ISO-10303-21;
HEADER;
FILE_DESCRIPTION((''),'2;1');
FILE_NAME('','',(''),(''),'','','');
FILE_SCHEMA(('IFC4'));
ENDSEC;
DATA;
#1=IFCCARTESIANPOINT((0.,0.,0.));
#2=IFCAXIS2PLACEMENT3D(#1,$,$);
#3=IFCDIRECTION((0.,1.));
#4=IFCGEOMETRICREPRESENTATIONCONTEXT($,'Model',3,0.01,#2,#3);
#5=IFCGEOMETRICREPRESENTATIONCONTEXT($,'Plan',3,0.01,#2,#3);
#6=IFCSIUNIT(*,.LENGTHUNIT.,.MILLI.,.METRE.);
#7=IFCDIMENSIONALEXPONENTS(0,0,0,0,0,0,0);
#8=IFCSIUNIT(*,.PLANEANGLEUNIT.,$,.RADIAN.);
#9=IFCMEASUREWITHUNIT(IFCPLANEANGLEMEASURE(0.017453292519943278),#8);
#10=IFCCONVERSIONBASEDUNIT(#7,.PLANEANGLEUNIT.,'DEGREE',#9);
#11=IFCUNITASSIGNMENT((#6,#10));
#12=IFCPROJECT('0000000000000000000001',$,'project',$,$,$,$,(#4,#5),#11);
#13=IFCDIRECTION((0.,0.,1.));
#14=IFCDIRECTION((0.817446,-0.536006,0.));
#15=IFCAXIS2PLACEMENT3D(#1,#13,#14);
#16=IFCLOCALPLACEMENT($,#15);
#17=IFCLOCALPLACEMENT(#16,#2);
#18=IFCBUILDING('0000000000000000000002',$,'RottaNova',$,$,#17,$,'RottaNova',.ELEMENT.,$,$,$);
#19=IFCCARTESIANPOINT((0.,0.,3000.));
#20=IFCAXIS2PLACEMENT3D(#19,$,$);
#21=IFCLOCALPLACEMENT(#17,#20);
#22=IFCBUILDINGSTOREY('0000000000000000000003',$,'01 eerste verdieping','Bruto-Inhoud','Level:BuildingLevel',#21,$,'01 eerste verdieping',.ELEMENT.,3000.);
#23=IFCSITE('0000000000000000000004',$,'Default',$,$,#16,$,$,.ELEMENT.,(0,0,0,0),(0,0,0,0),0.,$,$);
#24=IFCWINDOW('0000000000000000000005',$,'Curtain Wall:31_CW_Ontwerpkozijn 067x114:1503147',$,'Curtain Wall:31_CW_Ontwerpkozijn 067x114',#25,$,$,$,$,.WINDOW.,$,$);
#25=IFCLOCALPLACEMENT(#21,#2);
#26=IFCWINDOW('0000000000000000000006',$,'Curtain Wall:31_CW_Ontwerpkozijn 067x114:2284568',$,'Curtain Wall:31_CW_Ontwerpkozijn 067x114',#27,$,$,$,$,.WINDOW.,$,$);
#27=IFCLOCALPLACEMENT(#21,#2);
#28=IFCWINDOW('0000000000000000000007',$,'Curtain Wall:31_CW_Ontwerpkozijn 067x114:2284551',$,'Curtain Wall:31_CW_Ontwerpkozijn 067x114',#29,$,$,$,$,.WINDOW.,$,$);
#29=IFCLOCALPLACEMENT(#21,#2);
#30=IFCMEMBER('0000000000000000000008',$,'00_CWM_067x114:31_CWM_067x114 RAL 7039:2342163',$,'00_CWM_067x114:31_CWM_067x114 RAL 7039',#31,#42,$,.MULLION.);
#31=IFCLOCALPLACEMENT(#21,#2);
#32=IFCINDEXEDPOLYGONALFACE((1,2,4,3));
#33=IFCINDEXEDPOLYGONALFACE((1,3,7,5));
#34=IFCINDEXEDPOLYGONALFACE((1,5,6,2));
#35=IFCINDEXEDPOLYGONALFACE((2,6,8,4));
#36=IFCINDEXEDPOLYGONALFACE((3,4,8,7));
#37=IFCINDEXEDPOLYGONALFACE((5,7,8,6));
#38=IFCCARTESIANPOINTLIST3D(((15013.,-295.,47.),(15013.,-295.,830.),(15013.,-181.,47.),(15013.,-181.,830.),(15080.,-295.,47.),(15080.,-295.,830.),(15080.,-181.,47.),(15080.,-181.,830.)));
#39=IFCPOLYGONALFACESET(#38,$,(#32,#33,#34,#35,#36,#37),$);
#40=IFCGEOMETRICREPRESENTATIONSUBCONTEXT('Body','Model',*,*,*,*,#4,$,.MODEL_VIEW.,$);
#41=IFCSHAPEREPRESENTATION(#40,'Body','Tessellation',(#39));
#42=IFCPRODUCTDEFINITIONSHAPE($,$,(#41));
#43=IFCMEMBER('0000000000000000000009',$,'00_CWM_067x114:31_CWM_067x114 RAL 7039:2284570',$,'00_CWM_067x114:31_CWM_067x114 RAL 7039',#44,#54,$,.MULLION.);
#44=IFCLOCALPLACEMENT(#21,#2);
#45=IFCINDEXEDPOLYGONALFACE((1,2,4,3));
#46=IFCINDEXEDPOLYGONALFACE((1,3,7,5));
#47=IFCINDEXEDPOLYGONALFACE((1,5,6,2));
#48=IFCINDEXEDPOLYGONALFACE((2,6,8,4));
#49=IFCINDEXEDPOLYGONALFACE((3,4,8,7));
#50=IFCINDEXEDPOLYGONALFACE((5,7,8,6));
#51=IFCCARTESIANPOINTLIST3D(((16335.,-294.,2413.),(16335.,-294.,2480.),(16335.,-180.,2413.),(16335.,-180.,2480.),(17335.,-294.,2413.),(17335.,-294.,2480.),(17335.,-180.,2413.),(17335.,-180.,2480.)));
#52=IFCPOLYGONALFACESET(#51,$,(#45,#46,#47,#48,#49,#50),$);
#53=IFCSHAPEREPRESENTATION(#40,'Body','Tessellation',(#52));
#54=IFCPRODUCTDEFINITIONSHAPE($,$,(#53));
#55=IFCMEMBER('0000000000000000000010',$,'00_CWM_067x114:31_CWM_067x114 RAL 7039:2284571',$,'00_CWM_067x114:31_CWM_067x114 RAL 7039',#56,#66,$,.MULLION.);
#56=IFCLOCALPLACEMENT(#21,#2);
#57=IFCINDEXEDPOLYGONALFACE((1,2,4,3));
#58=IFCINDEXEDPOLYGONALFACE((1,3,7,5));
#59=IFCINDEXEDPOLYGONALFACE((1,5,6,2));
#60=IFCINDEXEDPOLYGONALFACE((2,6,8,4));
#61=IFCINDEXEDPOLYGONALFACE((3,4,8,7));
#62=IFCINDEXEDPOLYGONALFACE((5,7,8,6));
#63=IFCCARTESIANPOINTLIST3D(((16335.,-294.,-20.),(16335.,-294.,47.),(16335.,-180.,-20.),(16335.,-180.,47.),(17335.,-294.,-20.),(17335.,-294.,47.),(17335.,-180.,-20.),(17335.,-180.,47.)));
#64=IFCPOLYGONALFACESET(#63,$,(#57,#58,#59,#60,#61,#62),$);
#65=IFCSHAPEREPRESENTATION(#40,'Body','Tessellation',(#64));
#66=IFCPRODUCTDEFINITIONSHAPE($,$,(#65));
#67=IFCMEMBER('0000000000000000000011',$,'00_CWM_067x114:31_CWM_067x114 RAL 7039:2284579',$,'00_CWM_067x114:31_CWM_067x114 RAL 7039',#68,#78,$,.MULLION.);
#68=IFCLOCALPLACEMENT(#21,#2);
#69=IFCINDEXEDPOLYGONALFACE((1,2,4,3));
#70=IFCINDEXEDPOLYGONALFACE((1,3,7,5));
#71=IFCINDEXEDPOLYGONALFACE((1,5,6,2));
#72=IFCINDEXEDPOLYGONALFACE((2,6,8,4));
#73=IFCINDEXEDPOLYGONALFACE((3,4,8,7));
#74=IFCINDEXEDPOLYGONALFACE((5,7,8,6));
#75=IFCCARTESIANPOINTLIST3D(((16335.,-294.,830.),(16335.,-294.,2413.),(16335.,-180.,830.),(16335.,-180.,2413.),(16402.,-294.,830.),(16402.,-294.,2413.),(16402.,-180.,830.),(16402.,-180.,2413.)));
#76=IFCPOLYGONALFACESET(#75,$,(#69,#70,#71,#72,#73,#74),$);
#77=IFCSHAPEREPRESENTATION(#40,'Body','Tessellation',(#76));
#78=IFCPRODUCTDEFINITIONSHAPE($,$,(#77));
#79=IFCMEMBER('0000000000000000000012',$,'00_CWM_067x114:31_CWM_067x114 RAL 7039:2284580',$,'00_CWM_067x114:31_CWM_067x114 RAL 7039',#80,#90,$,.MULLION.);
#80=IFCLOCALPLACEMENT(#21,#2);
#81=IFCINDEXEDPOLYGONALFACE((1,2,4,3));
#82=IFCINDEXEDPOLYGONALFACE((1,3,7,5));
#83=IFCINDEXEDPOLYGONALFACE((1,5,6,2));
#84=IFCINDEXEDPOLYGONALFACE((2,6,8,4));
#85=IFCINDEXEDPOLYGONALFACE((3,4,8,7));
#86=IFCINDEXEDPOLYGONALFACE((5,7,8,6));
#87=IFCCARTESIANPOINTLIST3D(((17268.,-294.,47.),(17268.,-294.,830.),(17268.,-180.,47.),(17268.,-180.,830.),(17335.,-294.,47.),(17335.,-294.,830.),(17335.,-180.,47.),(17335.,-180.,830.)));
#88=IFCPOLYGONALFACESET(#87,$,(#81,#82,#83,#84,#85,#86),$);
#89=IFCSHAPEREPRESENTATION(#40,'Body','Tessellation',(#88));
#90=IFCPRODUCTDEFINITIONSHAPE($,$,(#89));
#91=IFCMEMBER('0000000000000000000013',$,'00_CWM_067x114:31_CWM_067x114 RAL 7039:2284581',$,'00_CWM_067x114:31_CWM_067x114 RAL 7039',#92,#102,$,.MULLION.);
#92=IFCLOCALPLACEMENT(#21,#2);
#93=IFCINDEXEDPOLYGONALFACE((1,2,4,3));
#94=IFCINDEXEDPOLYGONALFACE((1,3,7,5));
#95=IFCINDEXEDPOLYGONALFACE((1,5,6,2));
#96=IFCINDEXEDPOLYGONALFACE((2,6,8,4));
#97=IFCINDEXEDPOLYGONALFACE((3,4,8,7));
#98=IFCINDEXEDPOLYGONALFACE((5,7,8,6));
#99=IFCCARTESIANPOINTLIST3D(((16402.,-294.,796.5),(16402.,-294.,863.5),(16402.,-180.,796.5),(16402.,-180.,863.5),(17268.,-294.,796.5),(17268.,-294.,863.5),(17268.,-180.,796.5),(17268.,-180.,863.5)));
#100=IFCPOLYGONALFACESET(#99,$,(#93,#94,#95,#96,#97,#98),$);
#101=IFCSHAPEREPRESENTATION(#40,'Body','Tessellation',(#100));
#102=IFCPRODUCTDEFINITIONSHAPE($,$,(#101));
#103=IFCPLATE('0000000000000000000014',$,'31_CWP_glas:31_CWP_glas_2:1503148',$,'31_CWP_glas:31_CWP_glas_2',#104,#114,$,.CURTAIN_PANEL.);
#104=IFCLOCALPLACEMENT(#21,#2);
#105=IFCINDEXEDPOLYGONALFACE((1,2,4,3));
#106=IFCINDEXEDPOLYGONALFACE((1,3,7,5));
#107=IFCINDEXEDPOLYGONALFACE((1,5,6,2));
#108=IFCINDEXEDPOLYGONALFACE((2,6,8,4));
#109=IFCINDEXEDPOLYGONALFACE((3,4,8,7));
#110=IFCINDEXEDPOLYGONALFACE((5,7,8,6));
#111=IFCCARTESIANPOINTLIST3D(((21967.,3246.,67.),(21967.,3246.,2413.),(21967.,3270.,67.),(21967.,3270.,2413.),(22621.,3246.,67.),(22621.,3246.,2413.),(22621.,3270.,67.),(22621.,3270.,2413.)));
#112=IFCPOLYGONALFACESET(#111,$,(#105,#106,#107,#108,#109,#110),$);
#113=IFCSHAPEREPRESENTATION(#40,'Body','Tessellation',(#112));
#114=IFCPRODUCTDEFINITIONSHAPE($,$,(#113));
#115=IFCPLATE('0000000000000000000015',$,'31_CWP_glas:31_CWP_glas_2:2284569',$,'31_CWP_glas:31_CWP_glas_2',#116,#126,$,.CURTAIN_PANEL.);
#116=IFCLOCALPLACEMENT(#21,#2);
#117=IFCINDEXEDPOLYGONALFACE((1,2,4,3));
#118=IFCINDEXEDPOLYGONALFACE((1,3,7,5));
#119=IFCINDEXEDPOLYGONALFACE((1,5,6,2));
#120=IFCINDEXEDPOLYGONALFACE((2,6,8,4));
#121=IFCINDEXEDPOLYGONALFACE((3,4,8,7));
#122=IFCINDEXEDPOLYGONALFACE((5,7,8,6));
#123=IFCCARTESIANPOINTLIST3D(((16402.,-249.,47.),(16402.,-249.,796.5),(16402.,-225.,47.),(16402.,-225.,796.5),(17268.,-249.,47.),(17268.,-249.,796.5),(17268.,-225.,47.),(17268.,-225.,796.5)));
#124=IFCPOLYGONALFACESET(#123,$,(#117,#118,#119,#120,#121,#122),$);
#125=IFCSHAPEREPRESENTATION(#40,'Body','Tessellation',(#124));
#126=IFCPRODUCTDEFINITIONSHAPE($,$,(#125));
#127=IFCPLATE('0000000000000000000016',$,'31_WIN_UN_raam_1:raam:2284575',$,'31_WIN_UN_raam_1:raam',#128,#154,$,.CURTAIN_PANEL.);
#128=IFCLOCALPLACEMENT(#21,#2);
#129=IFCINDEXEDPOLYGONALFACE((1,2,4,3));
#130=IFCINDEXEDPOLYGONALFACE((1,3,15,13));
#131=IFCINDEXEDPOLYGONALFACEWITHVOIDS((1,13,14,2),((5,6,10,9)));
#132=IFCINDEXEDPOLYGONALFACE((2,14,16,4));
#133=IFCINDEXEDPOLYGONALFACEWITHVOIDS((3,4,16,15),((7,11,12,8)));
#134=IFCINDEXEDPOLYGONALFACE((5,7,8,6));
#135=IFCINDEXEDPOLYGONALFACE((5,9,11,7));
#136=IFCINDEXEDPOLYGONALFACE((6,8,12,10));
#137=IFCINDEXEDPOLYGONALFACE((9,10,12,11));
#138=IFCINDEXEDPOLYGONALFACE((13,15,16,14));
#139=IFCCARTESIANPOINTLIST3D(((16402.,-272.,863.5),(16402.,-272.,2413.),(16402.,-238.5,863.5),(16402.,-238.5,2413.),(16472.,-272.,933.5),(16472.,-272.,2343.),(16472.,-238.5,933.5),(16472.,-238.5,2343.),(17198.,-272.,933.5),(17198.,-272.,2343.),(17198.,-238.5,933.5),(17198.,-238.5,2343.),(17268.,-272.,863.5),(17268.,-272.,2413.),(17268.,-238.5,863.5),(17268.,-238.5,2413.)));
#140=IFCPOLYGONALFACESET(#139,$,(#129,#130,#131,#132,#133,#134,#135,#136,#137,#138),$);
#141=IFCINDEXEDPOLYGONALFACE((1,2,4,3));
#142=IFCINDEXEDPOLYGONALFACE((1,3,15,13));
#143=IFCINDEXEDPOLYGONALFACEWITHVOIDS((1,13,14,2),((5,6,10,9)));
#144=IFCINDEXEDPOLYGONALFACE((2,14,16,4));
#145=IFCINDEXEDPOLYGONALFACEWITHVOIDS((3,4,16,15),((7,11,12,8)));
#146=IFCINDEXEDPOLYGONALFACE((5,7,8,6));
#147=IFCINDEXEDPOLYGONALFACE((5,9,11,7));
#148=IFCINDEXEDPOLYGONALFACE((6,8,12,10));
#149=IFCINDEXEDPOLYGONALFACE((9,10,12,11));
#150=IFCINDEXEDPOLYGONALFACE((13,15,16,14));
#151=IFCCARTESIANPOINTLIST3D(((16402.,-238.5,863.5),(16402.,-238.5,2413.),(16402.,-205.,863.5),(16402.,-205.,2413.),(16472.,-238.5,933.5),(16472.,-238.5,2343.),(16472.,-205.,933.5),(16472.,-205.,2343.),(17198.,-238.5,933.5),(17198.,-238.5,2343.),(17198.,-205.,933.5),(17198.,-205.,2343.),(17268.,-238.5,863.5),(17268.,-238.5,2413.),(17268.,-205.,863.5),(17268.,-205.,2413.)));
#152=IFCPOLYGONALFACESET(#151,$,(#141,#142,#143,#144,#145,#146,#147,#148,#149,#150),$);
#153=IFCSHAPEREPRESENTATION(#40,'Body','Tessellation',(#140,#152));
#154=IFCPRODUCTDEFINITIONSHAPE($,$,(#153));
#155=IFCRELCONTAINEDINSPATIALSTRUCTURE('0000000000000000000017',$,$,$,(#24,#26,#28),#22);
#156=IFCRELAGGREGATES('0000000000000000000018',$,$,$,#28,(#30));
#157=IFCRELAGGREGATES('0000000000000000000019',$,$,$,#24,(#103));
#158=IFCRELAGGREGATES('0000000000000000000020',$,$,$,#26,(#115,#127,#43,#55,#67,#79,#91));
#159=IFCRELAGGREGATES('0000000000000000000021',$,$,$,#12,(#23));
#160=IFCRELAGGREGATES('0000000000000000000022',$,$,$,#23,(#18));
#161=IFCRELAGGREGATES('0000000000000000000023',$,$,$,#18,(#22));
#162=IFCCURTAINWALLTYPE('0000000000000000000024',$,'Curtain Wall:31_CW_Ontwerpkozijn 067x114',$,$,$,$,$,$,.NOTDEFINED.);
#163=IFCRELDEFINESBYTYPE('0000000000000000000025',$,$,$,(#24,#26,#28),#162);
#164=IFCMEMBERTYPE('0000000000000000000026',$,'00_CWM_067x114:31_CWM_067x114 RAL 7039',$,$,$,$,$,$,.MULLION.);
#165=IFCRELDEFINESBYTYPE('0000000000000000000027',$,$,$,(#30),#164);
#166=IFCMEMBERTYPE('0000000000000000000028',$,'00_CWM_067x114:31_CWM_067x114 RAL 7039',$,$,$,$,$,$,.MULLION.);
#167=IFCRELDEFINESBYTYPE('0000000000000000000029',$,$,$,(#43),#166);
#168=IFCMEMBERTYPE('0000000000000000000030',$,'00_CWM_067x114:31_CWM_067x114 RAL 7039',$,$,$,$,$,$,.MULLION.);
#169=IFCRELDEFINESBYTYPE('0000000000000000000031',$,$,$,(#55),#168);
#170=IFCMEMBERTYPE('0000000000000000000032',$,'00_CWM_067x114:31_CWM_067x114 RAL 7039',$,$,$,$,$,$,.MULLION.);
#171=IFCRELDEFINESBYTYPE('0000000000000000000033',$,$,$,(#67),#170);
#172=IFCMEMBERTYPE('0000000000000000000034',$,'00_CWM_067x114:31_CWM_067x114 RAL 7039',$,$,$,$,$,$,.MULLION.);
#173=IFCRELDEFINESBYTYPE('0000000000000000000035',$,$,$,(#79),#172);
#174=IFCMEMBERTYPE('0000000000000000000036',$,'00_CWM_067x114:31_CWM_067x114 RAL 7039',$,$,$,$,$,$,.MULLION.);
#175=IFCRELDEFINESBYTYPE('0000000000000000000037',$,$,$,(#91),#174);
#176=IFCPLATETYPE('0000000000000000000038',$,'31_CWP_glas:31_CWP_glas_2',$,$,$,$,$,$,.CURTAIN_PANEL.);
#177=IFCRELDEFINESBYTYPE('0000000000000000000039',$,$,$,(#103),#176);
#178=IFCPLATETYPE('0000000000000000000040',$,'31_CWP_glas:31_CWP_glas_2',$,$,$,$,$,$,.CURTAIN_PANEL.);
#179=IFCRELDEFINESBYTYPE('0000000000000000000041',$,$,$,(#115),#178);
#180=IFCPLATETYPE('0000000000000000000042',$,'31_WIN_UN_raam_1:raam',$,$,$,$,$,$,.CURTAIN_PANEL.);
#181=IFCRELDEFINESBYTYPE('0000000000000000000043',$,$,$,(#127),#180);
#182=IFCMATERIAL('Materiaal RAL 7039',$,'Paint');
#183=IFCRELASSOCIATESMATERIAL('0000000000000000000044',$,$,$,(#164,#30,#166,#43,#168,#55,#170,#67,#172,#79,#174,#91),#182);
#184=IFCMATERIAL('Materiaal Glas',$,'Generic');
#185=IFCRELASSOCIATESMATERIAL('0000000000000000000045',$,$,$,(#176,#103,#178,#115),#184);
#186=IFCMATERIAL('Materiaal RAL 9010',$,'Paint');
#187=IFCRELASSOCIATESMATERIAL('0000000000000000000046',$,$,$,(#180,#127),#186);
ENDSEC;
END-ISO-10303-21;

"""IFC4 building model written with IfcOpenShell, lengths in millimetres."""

from ifc_helpers import new_model, entity, si_unit, converted_unit, direction, frame, origin, place, context, subcontext, project, spatial, indexed_curve, outline, extrude, source, transform, mapped, material, type_object, type_shapes, element, aggregate, save


model = new_model("IFC4")

# Units and contexts
model_context = context("Model", 3, precision=0.01, world=origin(), true_north=direction((0.0, 1.0)))
plan_context = context("Plan", 3, precision=0.01, world=origin(), true_north=direction((0.0, 1.0)))
body_context = subcontext(model_context, "Body", "Model", "MODEL_VIEW")
ifc_project = project(units=[si_unit("LENGTHUNIT", "METRE", prefix="MILLI"), converted_unit("PLANEANGLEUNIT", "DEGREE", entity("IfcPlaneAngleMeasure", 0.017453292519943278), si_unit("PLANEANGLEUNIT", "RADIAN"), dimensions=[0, 0, 0, 0, 0, 0, 0])], contexts=[model_context, plan_context])

# Site, building, storey
site_placement = place(None, frame((0.0, 0.0, 0.0), z_axis=(0.0, 0.0, 1.0), x_axis=(0.817446, -0.536006, 0.0)))
site = spatial("IfcSite", under=ifc_project, at=site_placement, Name="Default", CompositionType="ELEMENT", RefLatitude=(0, 0, 0, 0), RefLongitude=(0, 0, 0, 0), RefElevation=0.0)
building_placement = place(site_placement, origin())
building = spatial("IfcBuilding", under=site, at=building_placement, Name="RottaNova", LongName="RottaNova", CompositionType="ELEMENT")
storey_placement = place(building_placement, frame((0.0, 0.0, 3000.0)))
storey = spatial("IfcBuildingStorey", under=building, at=storey_placement, Name="01 eerste verdieping", Description="Bruto-Inhoud", ObjectType="Level:BuildingLevel", LongName="01 eerste verdieping", CompositionType="ELEMENT", Elevation=3000.0)

# Window
curtain_wall_type = type_object("IfcCurtainWallType", Name="Curtain Wall:31_CW_Ontwerpkozijn 067x114", PredefinedType="NOTDEFINED")
ifc_material_1 = material(Name="Materiaal RAL 7039", Category="Paint")
window_1_placement = place(storey_placement, frame((0.0, 0.0, -3000.0)))
window_1 = element("IfcWindow", 1, at=window_1_placement, inside=storey, type_object=curtain_wall_type, Name="Curtain Wall:31_CW_Ontwerpkozijn 067x114:1503147", ObjectType="Curtain Wall:31_CW_Ontwerpkozijn 067x114", PredefinedType="WINDOW")

# Window
window_2_placement = place(storey_placement, frame((0.0, 0.0, -3000.0)))
window_2 = element("IfcWindow", 2, at=window_2_placement, inside=storey, type_object=curtain_wall_type, Name="Curtain Wall:31_CW_Ontwerpkozijn 067x114:2284568", ObjectType="Curtain Wall:31_CW_Ontwerpkozijn 067x114", PredefinedType="WINDOW")

# Window, member
window_3_placement = place(storey_placement, frame((0.0, 0.0, -3000.0)))
window_3 = element("IfcWindow", 3, at=window_3_placement, inside=storey, type_object=curtain_wall_type, Name="Curtain Wall:31_CW_Ontwerpkozijn 067x114:2284551", ObjectType="Curtain Wall:31_CW_Ontwerpkozijn 067x114", PredefinedType="WINDOW")
member_type_1 = type_object("IfcMemberType", Name="00_CWM_067x114:31_CWM_067x114 RAL 7039", PredefinedType="MULLION", material=ifc_material_1)
shared_shape_1 = source(origin(), body_context, "Body", "SweptSolid", [
    extrude(outline(indexed_curve([(-33.5, -57.0), (33.5, -57.0), (33.5, 57.0), (-33.5, 57.0), (-33.5, -57.0)], self_intersect=False)), frame((-33.5, -57.0, -783.0), z_axis=(0.0, 0.0, 1.0), x_axis=(-1.0, 0.0, 0.0)), (0.0, 0.0, 1.0), 783.0),
])
type_shapes(member_type_1, [shared_shape_1])
member_1_placement = place(window_3_placement, frame((15080.0, -181.0, 3830.0)))
member_1 = element("IfcMember", 4, at=member_1_placement, type_object=member_type_1, material=ifc_material_1, Name="00_CWM_067x114:31_CWM_067x114 RAL 7039:2342163", ObjectType="00_CWM_067x114:31_CWM_067x114 RAL 7039", PredefinedType="MULLION", context=body_context, shape_type="MappedRepresentation", body=[
    mapped(shared_shape_1, transform((0.0, 0.0, 0.0), scale=1.0)),
])
aggregate(window_3, [member_1])

# Members
member_type_2 = type_object("IfcMemberType", Name="00_CWM_067x114:31_CWM_067x114 RAL 7039", PredefinedType="MULLION", material=ifc_material_1)
shared_shape_2 = source(origin(), body_context, "Body", "SweptSolid", [
    extrude(outline(indexed_curve([(-33.5, -57.0), (33.5, -57.0), (33.5, 57.0), (-33.5, 57.0), (-33.5, -57.0)], self_intersect=False)), frame((-33.5, -57.0, -1000.0), z_axis=(0.0, 0.0, 1.0), x_axis=(-1.0, 0.0, 0.0)), (0.0, 0.0, 1.0), 1000.0),
])
type_shapes(member_type_2, [shared_shape_2])
member_2_placement = place(window_2_placement, frame((16335.0, -180.0, 5480.0), z_axis=(-1.0, 0.0, 0.0), x_axis=(0.0, 0.0, 1.0)))
member_2 = element("IfcMember", 5, at=member_2_placement, type_object=member_type_2, material=ifc_material_1, Name="00_CWM_067x114:31_CWM_067x114 RAL 7039:2284570", ObjectType="00_CWM_067x114:31_CWM_067x114 RAL 7039", PredefinedType="MULLION", context=body_context, shape_type="MappedRepresentation", body=[
    mapped(shared_shape_2, transform((0.0, 0.0, 0.0), scale=1.0)),
])
member_type_3 = type_object("IfcMemberType", Name="00_CWM_067x114:31_CWM_067x114 RAL 7039", PredefinedType="MULLION", material=ifc_material_1)
shared_shape_3 = source(origin(), body_context, "Body", "SweptSolid", [
    extrude(outline(indexed_curve([(-33.5, -57.0), (33.5, -57.0), (33.5, 57.0), (-33.5, 57.0), (-33.5, -57.0)], self_intersect=False)), frame((-33.5, -57.0, -1000.0), z_axis=(0.0, 0.0, 1.0), x_axis=(-1.0, 0.0, 0.0)), (0.0, 0.0, 1.0), 1000.0),
])
type_shapes(member_type_3, [shared_shape_3])
member_3_placement = place(window_2_placement, frame((17335.0, -180.0, 2980.0), z_axis=(1.0, 0.0, 0.0), x_axis=(0.0, 0.0, -1.0)))
member_3 = element("IfcMember", 6, at=member_3_placement, type_object=member_type_3, material=ifc_material_1, Name="00_CWM_067x114:31_CWM_067x114 RAL 7039:2284571", ObjectType="00_CWM_067x114:31_CWM_067x114 RAL 7039", PredefinedType="MULLION", context=body_context, shape_type="MappedRepresentation", body=[
    mapped(shared_shape_3, transform((0.0, 0.0, 0.0), scale=1.0)),
])
member_type_4 = type_object("IfcMemberType", Name="00_CWM_067x114:31_CWM_067x114 RAL 7039", PredefinedType="MULLION", material=ifc_material_1)
shared_shape_4 = source(origin(), body_context, "Body", "SweptSolid", [
    extrude(outline(indexed_curve([(-33.5, -57.0), (33.5, -57.0), (33.5, 57.0), (-33.5, 57.0), (-33.5, -57.0)], self_intersect=False)), frame((-33.5, -57.0, -1583.0), z_axis=(0.0, 0.0, 1.0), x_axis=(-1.0, 0.0, 0.0)), (0.0, 0.0, 1.0), 1583.0),
])
type_shapes(member_type_4, [shared_shape_4])
member_4_placement = place(window_2_placement, frame((16335.0, -180.0, 3830.0), z_axis=(0.0, 0.0, -1.0), x_axis=(-1.0, 0.0, 0.0)))
member_4 = element("IfcMember", 7, at=member_4_placement, type_object=member_type_4, material=ifc_material_1, Name="00_CWM_067x114:31_CWM_067x114 RAL 7039:2284579", ObjectType="00_CWM_067x114:31_CWM_067x114 RAL 7039", PredefinedType="MULLION", context=body_context, shape_type="MappedRepresentation", body=[
    mapped(shared_shape_4, transform((0.0, 0.0, 0.0), scale=1.0)),
])
member_type_5 = type_object("IfcMemberType", Name="00_CWM_067x114:31_CWM_067x114 RAL 7039", PredefinedType="MULLION", material=ifc_material_1)
shared_shape_5 = source(origin(), body_context, "Body", "SweptSolid", [
    extrude(outline(indexed_curve([(-33.5, -57.0), (33.5, -57.0), (33.5, 57.0), (-33.5, 57.0), (-33.5, -57.0)], self_intersect=False)), frame((-33.5, -57.0, -783.0), z_axis=(0.0, 0.0, 1.0), x_axis=(-1.0, 0.0, 0.0)), (0.0, 0.0, 1.0), 783.0),
])
type_shapes(member_type_5, [shared_shape_5])
member_5_placement = place(window_2_placement, frame((17335.0, -180.0, 3830.0)))
member_5 = element("IfcMember", 8, at=member_5_placement, type_object=member_type_5, material=ifc_material_1, Name="00_CWM_067x114:31_CWM_067x114 RAL 7039:2284580", ObjectType="00_CWM_067x114:31_CWM_067x114 RAL 7039", PredefinedType="MULLION", context=body_context, shape_type="MappedRepresentation", body=[
    mapped(shared_shape_5, transform((0.0, 0.0, 0.0), scale=1.0)),
])
member_type_6 = type_object("IfcMemberType", Name="00_CWM_067x114:31_CWM_067x114 RAL 7039", PredefinedType="MULLION", material=ifc_material_1)
shared_shape_6 = source(origin(), body_context, "Body", "SweptSolid", [
    extrude(outline(indexed_curve([(-33.5, -57.0), (33.5, -57.0), (33.5, 57.0), (-33.5, 57.0), (-33.5, -57.0)], self_intersect=False)), frame((0.0, -57.0, -866.0), z_axis=(0.0, 0.0, 1.0), x_axis=(-1.0, 0.0, 0.0)), (0.0, 0.0, 1.0), 866.0),
])
type_shapes(member_type_6, [shared_shape_6])
member_6_placement = place(window_2_placement, frame((16402.0, -180.0, 3830.0), z_axis=(-1.0, 0.0, 0.0), x_axis=(0.0, 0.0, 1.0)))
member_6 = element("IfcMember", 9, at=member_6_placement, type_object=member_type_6, material=ifc_material_1, Name="00_CWM_067x114:31_CWM_067x114 RAL 7039:2284581", ObjectType="00_CWM_067x114:31_CWM_067x114 RAL 7039", PredefinedType="MULLION", context=body_context, shape_type="MappedRepresentation", body=[
    mapped(shared_shape_6, transform((0.0, 0.0, 0.0), scale=1.0)),
])

# Plates
ifc_material_2 = material(Name="Materiaal Glas", Category="Generic")
plate_type_1 = type_object("IfcPlateType", Name="31_CWP_glas:31_CWP_glas_2", PredefinedType="CURTAIN_PANEL", material=ifc_material_2)
shared_shape_7 = source(origin(), body_context, "Body", "SweptSolid", [
    extrude(outline(indexed_curve([(-12.0, -327.0), (12.0, -327.0), (12.0, 327.0), (-12.0, 327.0), (-12.0, -327.0)], self_intersect=False)), frame((0.0, -57.0, 0.0), z_axis=(0.0, 0.0, 1.0), x_axis=(0.0, 1.0, 0.0)), (0.0, 0.0, 1.0), 2346.0),
])
type_shapes(plate_type_1, [shared_shape_7])
plate_1_placement = place(window_1_placement, frame((22294.0, 3315.0, 3067.0)))
plate_1 = element("IfcPlate", 10, at=plate_1_placement, type_object=plate_type_1, material=ifc_material_2, Name="31_CWP_glas:31_CWP_glas_2:1503148", ObjectType="31_CWP_glas:31_CWP_glas_2", PredefinedType="CURTAIN_PANEL", context=body_context, shape_type="MappedRepresentation", body=[
    mapped(shared_shape_7, transform((0.0, 0.0, 0.0), scale=1.0)),
])
aggregate(window_1, [plate_1])
plate_type_2 = type_object("IfcPlateType", Name="31_CWP_glas:31_CWP_glas_2", PredefinedType="CURTAIN_PANEL", material=ifc_material_2)
shared_shape_8 = source(origin(), body_context, "Body", "SweptSolid", [
    extrude(outline(indexed_curve([(-12.0, -433.0), (12.0, -433.0), (12.0, 433.0), (-12.0, 433.0), (-12.0, -433.0)], self_intersect=False)), frame((0.0, 57.0, 0.0), z_axis=(0.0, 0.0, 1.0), x_axis=(0.0, 1.0, 0.0)), (0.0, 0.0, 1.0), 749.5),
])
type_shapes(plate_type_2, [shared_shape_8])
plate_2_placement = place(window_2_placement, frame((16835.0, -180.0, 3047.0), z_axis=(0.0, 0.0, 1.0), x_axis=(-1.0, 0.0, 0.0)))
plate_2 = element("IfcPlate", 11, at=plate_2_placement, type_object=plate_type_2, material=ifc_material_2, Name="31_CWP_glas:31_CWP_glas_2:2284569", ObjectType="31_CWP_glas:31_CWP_glas_2", PredefinedType="CURTAIN_PANEL", context=body_context, shape_type="MappedRepresentation", body=[
    mapped(shared_shape_8, transform((0.0, 0.0, 0.0), scale=1.0)),
])
ifc_material_3 = material(Name="Materiaal RAL 9010", Category="Paint")
plate_type_3 = type_object("IfcPlateType", Name="31_WIN_UN_raam_1:raam", PredefinedType="CURTAIN_PANEL", material=ifc_material_3)
shared_shape_9 = source(origin(), body_context, "Body", "SweptSolid", [
    extrude(outline(indexed_curve([(-433.0, -774.7), (433.0, -774.7), (433.0, 774.7), (-433.0, 774.7), (-433.0, -774.7)], self_intersect=False), holes=[indexed_curve([(-363.0, 704.7), (363.0, 704.7), (363.0, -704.8), (-363.0, -704.8), (-363.0, 704.7)], self_intersect=False)]), frame((0.0, 58.5, 774.8), z_axis=(0.0, 1.0, 0.0), x_axis=(1.0, 0.0, 0.0)), (0.0, 0.0, 1.0), 33.5),
    extrude(outline(indexed_curve([(-433.0, -774.7), (433.0, -774.7), (433.0, 774.7), (-433.0, 774.7), (-433.0, -774.7)], self_intersect=False), holes=[indexed_curve([(-363.0, 704.7), (363.0, 704.7), (363.0, -704.8), (-363.0, -704.8), (-363.0, 704.7)], self_intersect=False)]), frame((0.0, 25.0, 774.8), z_axis=(0.0, 1.0, 0.0), x_axis=(1.0, 0.0, 0.0)), (0.0, 0.0, 1.0), 33.5),
])
type_shapes(plate_type_3, [shared_shape_9])
plate_3_placement = place(window_2_placement, frame((16835.0, -180.0, 3863.5), z_axis=(0.0, 0.0, 1.0), x_axis=(-1.0, 0.0, 0.0)))
plate_3 = element("IfcPlate", 12, at=plate_3_placement, type_object=plate_type_3, material=ifc_material_3, Name="31_WIN_UN_raam_1:raam:2284575", ObjectType="31_WIN_UN_raam_1:raam", PredefinedType="CURTAIN_PANEL", context=body_context, shape_type="MappedRepresentation", body=[
    mapped(shared_shape_9, transform((0.0, 0.0, 0.0), scale=1.0)),
])
aggregate(window_2, [plate_2, plate_3, member_2, member_3, member_4, member_5, member_6])

save(model, "model.ifc")
